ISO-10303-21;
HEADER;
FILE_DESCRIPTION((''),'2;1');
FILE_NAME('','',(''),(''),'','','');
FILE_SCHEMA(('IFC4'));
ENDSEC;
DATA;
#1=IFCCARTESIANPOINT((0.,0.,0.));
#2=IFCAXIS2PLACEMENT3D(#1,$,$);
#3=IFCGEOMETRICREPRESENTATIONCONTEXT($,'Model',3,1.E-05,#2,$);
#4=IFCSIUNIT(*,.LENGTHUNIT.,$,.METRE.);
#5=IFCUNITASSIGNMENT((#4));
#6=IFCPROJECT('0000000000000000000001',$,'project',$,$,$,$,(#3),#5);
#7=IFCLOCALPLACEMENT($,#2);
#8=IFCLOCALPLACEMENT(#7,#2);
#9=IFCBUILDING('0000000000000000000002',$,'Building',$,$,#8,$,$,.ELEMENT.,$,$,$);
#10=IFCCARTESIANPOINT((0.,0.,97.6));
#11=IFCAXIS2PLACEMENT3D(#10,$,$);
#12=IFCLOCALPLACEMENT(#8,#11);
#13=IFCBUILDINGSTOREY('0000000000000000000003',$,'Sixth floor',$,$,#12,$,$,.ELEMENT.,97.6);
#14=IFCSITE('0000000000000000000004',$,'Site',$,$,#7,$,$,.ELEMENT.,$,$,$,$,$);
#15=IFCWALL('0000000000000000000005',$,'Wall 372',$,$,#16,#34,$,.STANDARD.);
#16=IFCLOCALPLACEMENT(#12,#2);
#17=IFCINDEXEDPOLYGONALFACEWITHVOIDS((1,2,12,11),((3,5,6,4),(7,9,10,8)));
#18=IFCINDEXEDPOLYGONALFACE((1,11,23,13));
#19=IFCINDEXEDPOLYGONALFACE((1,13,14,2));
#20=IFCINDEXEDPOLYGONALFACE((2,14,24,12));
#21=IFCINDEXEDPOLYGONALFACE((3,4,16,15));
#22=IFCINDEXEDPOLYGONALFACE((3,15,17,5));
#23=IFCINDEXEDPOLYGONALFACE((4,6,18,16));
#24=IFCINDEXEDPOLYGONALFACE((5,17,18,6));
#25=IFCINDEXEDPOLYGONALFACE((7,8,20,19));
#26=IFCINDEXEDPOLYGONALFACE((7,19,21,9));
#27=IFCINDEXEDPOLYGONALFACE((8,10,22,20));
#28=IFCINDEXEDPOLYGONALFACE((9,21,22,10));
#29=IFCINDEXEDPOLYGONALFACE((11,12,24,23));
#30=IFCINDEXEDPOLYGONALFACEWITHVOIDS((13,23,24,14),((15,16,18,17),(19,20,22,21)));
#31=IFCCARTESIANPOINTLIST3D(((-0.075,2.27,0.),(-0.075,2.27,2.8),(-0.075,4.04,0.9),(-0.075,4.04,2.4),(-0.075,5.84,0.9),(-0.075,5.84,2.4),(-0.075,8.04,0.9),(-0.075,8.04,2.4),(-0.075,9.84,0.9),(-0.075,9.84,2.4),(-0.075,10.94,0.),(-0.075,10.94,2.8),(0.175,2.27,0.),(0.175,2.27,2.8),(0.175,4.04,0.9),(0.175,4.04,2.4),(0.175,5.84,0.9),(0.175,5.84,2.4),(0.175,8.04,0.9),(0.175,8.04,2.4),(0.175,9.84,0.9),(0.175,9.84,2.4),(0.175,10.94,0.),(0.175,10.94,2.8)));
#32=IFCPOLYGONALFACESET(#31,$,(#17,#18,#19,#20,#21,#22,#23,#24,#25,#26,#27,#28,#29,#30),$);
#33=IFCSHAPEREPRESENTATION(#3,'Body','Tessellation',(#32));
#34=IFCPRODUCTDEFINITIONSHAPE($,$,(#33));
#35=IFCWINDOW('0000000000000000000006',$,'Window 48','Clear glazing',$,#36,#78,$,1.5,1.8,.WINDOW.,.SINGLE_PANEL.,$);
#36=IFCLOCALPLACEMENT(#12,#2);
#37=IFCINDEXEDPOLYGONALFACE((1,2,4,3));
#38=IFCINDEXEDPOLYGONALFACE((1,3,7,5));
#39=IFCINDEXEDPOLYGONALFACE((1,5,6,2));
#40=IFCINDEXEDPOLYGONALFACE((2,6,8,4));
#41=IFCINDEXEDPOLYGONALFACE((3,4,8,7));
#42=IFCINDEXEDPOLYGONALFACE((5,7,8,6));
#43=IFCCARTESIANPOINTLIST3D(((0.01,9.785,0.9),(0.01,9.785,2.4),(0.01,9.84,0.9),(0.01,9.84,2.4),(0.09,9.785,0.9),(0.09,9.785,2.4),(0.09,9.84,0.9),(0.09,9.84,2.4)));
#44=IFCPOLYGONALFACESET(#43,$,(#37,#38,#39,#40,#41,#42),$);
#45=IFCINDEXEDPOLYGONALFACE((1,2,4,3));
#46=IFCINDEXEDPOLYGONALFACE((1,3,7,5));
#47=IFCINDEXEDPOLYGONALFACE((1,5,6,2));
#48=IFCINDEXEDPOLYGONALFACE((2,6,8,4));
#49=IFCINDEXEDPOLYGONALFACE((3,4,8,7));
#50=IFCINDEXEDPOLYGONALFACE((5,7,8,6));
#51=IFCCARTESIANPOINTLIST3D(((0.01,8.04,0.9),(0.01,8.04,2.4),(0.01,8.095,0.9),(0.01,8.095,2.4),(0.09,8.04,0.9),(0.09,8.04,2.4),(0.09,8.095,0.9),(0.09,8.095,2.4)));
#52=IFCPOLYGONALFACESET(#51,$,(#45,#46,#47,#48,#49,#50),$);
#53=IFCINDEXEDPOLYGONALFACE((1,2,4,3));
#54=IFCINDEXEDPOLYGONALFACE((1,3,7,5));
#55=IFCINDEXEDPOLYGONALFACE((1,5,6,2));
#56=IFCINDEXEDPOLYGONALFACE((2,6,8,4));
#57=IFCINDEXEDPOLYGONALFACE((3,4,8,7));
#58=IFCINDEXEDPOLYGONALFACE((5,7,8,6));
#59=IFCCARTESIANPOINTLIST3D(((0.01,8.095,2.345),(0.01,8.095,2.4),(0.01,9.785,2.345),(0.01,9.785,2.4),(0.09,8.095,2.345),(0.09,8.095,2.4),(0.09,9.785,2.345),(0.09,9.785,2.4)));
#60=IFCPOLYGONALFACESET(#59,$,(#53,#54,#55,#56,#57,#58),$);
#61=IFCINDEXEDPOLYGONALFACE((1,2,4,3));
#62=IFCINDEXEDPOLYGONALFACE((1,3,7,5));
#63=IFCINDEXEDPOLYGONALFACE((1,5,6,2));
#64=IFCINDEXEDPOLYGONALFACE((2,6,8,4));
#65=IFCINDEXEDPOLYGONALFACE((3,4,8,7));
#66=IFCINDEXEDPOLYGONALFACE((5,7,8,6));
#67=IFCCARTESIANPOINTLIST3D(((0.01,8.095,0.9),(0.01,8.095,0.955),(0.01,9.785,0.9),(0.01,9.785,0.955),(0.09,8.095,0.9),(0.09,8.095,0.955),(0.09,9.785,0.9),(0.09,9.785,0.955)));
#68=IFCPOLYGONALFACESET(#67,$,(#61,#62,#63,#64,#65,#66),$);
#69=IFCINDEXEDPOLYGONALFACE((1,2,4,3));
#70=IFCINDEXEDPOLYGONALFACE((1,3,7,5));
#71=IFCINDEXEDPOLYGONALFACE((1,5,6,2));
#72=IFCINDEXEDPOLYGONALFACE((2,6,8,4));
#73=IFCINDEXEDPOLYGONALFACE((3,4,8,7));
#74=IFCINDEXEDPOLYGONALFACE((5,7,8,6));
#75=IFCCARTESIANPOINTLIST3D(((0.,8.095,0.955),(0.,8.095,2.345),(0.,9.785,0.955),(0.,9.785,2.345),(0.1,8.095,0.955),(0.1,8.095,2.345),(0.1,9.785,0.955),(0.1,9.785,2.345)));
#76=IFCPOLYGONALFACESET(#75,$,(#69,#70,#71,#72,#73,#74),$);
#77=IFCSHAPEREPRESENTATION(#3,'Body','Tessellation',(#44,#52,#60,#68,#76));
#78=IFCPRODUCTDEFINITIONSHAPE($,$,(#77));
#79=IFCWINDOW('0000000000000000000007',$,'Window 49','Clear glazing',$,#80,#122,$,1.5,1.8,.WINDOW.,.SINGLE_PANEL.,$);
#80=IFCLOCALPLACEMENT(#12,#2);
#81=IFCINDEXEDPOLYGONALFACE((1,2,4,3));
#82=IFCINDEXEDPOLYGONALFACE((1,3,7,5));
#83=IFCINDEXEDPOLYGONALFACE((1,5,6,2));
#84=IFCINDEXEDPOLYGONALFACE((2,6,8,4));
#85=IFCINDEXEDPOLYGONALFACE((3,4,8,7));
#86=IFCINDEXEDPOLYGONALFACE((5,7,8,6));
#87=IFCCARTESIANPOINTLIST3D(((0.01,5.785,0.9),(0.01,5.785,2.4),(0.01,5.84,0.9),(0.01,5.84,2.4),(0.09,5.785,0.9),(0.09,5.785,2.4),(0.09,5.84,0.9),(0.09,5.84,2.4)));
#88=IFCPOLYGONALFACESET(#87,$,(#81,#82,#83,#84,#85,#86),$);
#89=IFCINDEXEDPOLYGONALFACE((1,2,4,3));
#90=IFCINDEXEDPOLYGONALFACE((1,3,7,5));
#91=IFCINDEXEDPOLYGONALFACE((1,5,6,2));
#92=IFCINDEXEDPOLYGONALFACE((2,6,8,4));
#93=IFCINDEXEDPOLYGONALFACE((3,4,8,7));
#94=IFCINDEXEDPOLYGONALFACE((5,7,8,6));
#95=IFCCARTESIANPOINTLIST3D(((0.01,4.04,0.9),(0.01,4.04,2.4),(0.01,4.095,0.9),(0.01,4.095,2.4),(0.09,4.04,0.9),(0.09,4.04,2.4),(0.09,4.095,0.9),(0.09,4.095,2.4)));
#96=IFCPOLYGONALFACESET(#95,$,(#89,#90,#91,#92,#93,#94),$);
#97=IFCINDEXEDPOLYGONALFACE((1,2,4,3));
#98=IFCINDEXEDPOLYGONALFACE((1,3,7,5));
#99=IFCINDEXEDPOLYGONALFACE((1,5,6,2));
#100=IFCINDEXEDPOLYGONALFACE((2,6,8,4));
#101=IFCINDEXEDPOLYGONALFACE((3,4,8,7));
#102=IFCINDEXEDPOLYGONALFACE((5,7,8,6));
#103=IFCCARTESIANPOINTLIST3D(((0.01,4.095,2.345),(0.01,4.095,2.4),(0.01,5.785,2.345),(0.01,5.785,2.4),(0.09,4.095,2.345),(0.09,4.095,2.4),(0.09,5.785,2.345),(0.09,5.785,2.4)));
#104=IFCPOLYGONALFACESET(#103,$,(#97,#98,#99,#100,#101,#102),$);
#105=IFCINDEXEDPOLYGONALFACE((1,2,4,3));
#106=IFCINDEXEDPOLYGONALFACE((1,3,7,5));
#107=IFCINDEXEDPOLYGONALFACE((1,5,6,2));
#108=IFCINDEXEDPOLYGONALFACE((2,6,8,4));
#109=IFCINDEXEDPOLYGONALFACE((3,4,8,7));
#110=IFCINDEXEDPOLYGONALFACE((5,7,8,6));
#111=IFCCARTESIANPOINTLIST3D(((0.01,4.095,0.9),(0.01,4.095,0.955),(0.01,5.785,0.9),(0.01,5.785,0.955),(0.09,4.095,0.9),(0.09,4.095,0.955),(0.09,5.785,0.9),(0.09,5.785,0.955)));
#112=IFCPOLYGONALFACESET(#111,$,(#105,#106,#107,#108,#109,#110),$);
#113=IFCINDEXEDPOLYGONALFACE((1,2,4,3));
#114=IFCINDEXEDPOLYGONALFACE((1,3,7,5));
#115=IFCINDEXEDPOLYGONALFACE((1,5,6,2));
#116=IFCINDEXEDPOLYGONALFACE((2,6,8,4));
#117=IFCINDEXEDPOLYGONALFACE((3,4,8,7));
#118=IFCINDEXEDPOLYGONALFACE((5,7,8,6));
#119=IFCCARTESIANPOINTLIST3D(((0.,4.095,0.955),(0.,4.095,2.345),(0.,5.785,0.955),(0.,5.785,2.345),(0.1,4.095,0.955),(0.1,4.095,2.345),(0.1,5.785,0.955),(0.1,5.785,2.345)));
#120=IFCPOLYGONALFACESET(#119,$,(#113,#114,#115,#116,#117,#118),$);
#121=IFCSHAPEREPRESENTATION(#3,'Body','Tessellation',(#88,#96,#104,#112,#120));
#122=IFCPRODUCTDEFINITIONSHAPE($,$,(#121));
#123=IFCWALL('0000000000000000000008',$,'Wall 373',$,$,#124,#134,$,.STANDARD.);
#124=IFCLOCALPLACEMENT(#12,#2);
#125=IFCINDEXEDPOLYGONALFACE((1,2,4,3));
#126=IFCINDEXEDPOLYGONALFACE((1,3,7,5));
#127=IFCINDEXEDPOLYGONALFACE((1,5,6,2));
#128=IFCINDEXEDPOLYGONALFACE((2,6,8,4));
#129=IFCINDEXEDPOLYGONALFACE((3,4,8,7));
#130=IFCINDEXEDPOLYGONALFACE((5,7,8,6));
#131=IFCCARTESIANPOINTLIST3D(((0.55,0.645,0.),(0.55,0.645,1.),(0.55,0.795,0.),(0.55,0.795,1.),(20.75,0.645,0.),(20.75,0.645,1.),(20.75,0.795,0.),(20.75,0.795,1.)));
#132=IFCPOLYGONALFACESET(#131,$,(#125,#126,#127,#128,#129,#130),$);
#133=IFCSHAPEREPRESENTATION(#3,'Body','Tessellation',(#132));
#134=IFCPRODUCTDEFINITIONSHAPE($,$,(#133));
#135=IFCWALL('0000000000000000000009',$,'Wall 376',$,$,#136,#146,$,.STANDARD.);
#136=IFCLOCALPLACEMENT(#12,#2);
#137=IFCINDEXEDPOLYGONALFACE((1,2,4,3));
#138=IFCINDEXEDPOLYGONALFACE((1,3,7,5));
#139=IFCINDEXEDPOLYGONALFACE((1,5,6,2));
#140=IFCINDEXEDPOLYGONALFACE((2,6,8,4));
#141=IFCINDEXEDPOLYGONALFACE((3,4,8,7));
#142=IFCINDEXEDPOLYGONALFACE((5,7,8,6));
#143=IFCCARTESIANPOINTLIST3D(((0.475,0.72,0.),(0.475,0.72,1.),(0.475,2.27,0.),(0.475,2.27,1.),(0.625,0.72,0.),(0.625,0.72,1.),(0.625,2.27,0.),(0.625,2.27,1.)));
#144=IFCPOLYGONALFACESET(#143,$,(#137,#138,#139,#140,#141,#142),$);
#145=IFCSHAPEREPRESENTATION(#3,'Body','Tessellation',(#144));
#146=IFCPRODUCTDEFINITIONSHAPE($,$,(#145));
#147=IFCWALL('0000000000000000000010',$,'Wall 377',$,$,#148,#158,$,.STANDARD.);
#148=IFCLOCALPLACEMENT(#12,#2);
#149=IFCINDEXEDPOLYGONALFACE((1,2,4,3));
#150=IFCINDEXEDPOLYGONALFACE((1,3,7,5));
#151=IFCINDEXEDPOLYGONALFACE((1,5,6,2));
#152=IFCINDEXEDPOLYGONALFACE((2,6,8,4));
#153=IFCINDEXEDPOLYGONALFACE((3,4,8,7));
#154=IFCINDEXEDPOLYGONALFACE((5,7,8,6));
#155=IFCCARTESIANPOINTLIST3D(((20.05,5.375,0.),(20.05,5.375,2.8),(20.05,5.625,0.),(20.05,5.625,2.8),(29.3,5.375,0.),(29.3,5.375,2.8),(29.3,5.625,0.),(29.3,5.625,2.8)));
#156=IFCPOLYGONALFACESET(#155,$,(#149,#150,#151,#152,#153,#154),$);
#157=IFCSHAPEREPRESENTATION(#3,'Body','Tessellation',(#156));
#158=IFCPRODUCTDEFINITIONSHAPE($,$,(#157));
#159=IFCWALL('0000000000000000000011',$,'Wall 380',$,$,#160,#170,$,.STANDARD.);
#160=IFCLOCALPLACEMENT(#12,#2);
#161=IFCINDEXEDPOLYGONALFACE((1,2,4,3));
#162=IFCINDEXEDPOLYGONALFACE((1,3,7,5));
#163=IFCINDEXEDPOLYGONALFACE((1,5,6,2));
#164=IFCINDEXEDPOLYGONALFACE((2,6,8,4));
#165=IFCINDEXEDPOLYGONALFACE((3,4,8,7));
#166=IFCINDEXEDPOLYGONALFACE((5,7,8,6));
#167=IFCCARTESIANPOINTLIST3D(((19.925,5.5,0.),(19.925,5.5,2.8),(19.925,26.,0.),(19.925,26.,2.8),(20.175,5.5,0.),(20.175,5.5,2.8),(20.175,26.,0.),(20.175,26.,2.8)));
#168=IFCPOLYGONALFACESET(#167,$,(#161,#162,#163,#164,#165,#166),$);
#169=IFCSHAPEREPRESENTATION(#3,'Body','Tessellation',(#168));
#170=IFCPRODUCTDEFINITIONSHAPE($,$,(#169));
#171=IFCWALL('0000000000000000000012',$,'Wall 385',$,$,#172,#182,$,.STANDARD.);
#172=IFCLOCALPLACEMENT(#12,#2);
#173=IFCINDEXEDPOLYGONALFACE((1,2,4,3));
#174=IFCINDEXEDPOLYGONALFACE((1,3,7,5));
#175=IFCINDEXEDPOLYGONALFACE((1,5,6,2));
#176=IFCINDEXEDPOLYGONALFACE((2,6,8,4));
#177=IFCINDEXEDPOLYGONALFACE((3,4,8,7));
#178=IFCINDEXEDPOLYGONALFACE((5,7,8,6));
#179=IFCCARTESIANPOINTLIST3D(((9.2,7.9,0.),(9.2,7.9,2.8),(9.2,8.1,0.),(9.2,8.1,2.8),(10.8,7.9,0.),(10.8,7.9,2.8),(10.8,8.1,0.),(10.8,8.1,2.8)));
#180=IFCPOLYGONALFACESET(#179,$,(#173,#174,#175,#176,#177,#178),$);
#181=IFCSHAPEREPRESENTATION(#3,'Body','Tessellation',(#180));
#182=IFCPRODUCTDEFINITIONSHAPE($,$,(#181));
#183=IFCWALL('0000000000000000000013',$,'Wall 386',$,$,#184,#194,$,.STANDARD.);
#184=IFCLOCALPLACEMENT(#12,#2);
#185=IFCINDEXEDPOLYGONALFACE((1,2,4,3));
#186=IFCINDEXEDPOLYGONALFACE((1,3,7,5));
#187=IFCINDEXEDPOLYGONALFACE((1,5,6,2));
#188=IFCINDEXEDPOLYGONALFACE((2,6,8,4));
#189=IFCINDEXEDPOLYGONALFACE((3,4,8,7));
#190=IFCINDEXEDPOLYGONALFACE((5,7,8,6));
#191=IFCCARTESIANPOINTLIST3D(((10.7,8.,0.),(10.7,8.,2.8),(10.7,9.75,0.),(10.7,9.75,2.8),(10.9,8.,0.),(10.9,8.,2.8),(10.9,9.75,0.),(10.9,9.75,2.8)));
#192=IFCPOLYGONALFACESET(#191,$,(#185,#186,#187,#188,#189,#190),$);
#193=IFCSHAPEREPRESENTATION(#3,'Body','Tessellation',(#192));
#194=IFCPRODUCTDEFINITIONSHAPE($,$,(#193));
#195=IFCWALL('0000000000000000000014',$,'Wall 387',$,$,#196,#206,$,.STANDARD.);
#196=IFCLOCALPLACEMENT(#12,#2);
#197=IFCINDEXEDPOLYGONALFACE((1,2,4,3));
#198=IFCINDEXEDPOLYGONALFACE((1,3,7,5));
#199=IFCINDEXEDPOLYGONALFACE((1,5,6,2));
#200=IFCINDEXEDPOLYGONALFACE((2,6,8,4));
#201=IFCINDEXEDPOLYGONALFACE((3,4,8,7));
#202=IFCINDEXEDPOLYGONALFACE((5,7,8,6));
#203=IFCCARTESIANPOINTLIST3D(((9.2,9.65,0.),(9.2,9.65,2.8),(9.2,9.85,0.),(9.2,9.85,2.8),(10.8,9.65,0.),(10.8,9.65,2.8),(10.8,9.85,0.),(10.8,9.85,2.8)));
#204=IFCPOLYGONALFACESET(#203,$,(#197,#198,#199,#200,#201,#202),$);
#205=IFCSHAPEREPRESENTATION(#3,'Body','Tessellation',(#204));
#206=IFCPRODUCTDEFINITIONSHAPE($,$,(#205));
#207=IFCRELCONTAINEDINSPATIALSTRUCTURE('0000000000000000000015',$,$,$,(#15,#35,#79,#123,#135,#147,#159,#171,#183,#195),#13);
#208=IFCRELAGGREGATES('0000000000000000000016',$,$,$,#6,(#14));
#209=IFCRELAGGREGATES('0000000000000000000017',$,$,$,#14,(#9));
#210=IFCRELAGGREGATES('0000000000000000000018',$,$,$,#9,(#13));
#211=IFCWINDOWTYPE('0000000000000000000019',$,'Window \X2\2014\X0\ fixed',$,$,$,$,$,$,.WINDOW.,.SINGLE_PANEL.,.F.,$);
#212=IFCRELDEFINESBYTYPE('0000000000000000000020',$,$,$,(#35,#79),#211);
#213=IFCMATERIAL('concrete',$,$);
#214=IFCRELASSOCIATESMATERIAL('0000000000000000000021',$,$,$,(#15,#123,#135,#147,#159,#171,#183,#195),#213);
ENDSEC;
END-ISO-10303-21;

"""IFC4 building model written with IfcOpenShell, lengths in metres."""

from ifc_helpers import new_model, si_unit, frame, frame_2d, origin, place, context, project, spatial, rectangle, extrude, material, type_object, element, fill, save


model = new_model("IFC4")

# Units and contexts
model_context = context("Model", 3, precision=1e-05, world=origin())
ifc_project = project(units=[si_unit("LENGTHUNIT", "METRE")], contexts=[model_context])

# Site, building, storey
site_placement = place(None, origin())
site = spatial("IfcSite", under=ifc_project, at=site_placement, Name="Site", CompositionType="ELEMENT")
building_placement = place(site_placement, origin())
building = spatial("IfcBuilding", under=site, at=building_placement, Name="Building", CompositionType="ELEMENT")
storey_placement = place(building_placement, frame((0.0, 0.0, 97.6)))
storey = spatial("IfcBuildingStorey", under=building, at=storey_placement, Name="Sixth floor", CompositionType="ELEMENT", Elevation=97.6)

# Shared definitions
ifc_material = material(Name="concrete")

# Shared definitions
window_type = type_object("IfcWindowType", Name="Window — fixed", ParameterTakesPrecedence=False, PartitioningType="SINGLE_PANEL", PredefinedType="WINDOW")

# Wall, openings, windows
wall_1_placement = place(storey_placement, frame((0.05, 10.94, 0.0), z_axis=(0.0, 0.0, 1.0), x_axis=(0.0, -1.0, 0.0)))
wall_1 = element("IfcWall", 1, at=wall_1_placement, inside=storey, material=ifc_material, Name="Wall 372", PredefinedType="STANDARD", context=model_context, shape_type="SweptSolid", body=[
    extrude(rectangle(XDim=8.67, YDim=0.25, at=frame_2d((4.335, 0.0))), origin(), (0.0, 0.0, 1.0), 2.8),
])
opening_1_placement = place(storey_placement, frame((0.05, 9.84, 0.9), z_axis=(0.0, 0.0, 1.0), x_axis=(0.0, -1.0, 0.0)))
opening_1 = element("IfcOpeningElement", 2, at=opening_1_placement, cuts=wall_1, PredefinedType="OPENING", context=model_context, shape_type="SweptSolid", body=[
    extrude(rectangle(XDim=1.8, YDim=0.31, at=frame_2d((0.9, 0.0))), origin(), (0.0, 0.0, 1.0), 1.5),
])
opening_2_placement = place(storey_placement, frame((0.05, 5.84, 0.9), z_axis=(0.0, 0.0, 1.0), x_axis=(0.0, -1.0, 0.0)))
opening_2 = element("IfcOpeningElement", 3, at=opening_2_placement, cuts=wall_1, PredefinedType="OPENING", context=model_context, shape_type="SweptSolid", body=[
    extrude(rectangle(XDim=1.8, YDim=0.31, at=frame_2d((0.9, 0.0))), origin(), (0.0, 0.0, 1.0), 1.5),
])
window_1_placement = place(storey_placement, frame((0.05, 9.84, 0.9), z_axis=(0.0, 0.0, 1.0), x_axis=(0.0, -1.0, 0.0)))
window_1 = element("IfcWindow", 4, at=window_1_placement, inside=storey, type_object=window_type, Name="Window 48", Description="Clear glazing", OverallHeight=1.5, OverallWidth=1.8, PartitioningType="SINGLE_PANEL", PredefinedType="WINDOW", context=model_context, shape_type="SweptSolid", body=[
    extrude(rectangle(XDim=0.055, YDim=0.08, at=frame_2d((0.0275, 0.0))), origin(), (0.0, 0.0, 1.0), 1.5),
    extrude(rectangle(XDim=0.055, YDim=0.08, at=frame_2d((1.7725, 0.0))), origin(), (0.0, 0.0, 1.0), 1.5),
    extrude(rectangle(XDim=1.69, YDim=0.08, at=frame_2d((0.9, 0.0))), frame((0.0, 0.0, 1.445)), (0.0, 0.0, 1.0), 0.055),
    extrude(rectangle(XDim=1.69, YDim=0.08, at=frame_2d((0.9, 0.0))), origin(), (0.0, 0.0, 1.0), 0.055),
    extrude(rectangle(XDim=1.69, YDim=0.1, at=frame_2d((0.9, 0.0))), frame((0.0, 0.0, 0.055)), (0.0, 0.0, 1.0), 1.39),
])
fill(opening_1, window_1)
window_2_placement = place(storey_placement, frame((0.05, 5.84, 0.9), z_axis=(0.0, 0.0, 1.0), x_axis=(0.0, -1.0, 0.0)))
window_2 = element("IfcWindow", 5, at=window_2_placement, inside=storey, type_object=window_type, Name="Window 49", Description="Clear glazing", OverallHeight=1.5, OverallWidth=1.8, PartitioningType="SINGLE_PANEL", PredefinedType="WINDOW", context=model_context, shape_type="SweptSolid", body=[
    extrude(rectangle(XDim=0.055, YDim=0.08, at=frame_2d((0.0275, 0.0))), origin(), (0.0, 0.0, 1.0), 1.5),
    extrude(rectangle(XDim=0.055, YDim=0.08, at=frame_2d((1.7725, 0.0))), origin(), (0.0, 0.0, 1.0), 1.5),
    extrude(rectangle(XDim=1.69, YDim=0.08, at=frame_2d((0.9, 0.0))), frame((0.0, 0.0, 1.445)), (0.0, 0.0, 1.0), 0.055),
    extrude(rectangle(XDim=1.69, YDim=0.08, at=frame_2d((0.9, 0.0))), origin(), (0.0, 0.0, 1.0), 0.055),
    extrude(rectangle(XDim=1.69, YDim=0.1, at=frame_2d((0.9, 0.0))), frame((0.0, 0.0, 0.055)), (0.0, 0.0, 1.0), 1.39),
])
fill(opening_2, window_2)

# Walls
wall_2_placement = place(storey_placement, frame((0.55, 0.72, 0.0), z_axis=(0.0, 0.0, 1.0), x_axis=(1.0, 0.0, 0.0)))
element("IfcWall", 6, at=wall_2_placement, inside=storey, material=ifc_material, Name="Wall 373", PredefinedType="STANDARD", context=model_context, shape_type="SweptSolid", body=[
    extrude(rectangle(XDim=20.2, YDim=0.15, at=frame_2d((10.1, 0.0))), origin(), (0.0, 0.0, 1.0), 1.0),
])
wall_3_placement = place(storey_placement, frame((0.55, 2.27, 0.0), z_axis=(0.0, 0.0, 1.0), x_axis=(0.0, -1.0, 0.0)))
element("IfcWall", 7, at=wall_3_placement, inside=storey, material=ifc_material, Name="Wall 376", PredefinedType="STANDARD", context=model_context, shape_type="SweptSolid", body=[
    extrude(rectangle(XDim=1.55, YDim=0.15, at=frame_2d((0.775, 0.0))), origin(), (0.0, 0.0, 1.0), 1.0),
])
wall_4_placement = place(storey_placement, frame((20.05, 5.5, 0.0), z_axis=(0.0, 0.0, 1.0), x_axis=(1.0, 0.0, 0.0)))
element("IfcWall", 8, at=wall_4_placement, inside=storey, material=ifc_material, Name="Wall 377", PredefinedType="STANDARD", context=model_context, shape_type="SweptSolid", body=[
    extrude(rectangle(XDim=9.25, YDim=0.25, at=frame_2d((4.625, 0.0))), origin(), (0.0, 0.0, 1.0), 2.8),
])
wall_5_placement = place(storey_placement, frame((20.05, 26.0, 0.0), z_axis=(0.0, 0.0, 1.0), x_axis=(0.0, -1.0, 0.0)))
element("IfcWall", 9, at=wall_5_placement, inside=storey, material=ifc_material, Name="Wall 380", PredefinedType="STANDARD", context=model_context, shape_type="SweptSolid", body=[
    extrude(rectangle(XDim=20.5, YDim=0.25, at=frame_2d((10.25, 0.0))), origin(), (0.0, 0.0, 1.0), 2.8),
])
wall_6_placement = place(storey_placement, frame((9.2, 8.0, 0.0), z_axis=(0.0, 0.0, 1.0), x_axis=(1.0, 0.0, 0.0)))
element("IfcWall", 10, at=wall_6_placement, inside=storey, material=ifc_material, Name="Wall 385", PredefinedType="STANDARD", context=model_context, shape_type="SweptSolid", body=[
    extrude(rectangle(XDim=1.6, YDim=0.2, at=frame_2d((0.8, 0.0))), origin(), (0.0, 0.0, 1.0), 2.8),
])
wall_7_placement = place(storey_placement, frame((10.8, 8.0, 0.0), z_axis=(0.0, 0.0, 1.0), x_axis=(0.0, 1.0, 0.0)))
element("IfcWall", 11, at=wall_7_placement, inside=storey, material=ifc_material, Name="Wall 386", PredefinedType="STANDARD", context=model_context, shape_type="SweptSolid", body=[
    extrude(rectangle(XDim=1.75, YDim=0.2, at=frame_2d((0.875, 0.0))), origin(), (0.0, 0.0, 1.0), 2.8),
])
wall_8_placement = place(storey_placement, frame((10.8, 9.75, 0.0), z_axis=(0.0, 0.0, 1.0), x_axis=(-1.0, 0.0, 0.0)))
element("IfcWall", 12, at=wall_8_placement, inside=storey, material=ifc_material, Name="Wall 387", PredefinedType="STANDARD", context=model_context, shape_type="SweptSolid", body=[
    extrude(rectangle(XDim=1.6, YDim=0.2, at=frame_2d((0.8, 0.0))), origin(), (0.0, 0.0, 1.0), 2.8),
])

save(model, "model.ifc")
